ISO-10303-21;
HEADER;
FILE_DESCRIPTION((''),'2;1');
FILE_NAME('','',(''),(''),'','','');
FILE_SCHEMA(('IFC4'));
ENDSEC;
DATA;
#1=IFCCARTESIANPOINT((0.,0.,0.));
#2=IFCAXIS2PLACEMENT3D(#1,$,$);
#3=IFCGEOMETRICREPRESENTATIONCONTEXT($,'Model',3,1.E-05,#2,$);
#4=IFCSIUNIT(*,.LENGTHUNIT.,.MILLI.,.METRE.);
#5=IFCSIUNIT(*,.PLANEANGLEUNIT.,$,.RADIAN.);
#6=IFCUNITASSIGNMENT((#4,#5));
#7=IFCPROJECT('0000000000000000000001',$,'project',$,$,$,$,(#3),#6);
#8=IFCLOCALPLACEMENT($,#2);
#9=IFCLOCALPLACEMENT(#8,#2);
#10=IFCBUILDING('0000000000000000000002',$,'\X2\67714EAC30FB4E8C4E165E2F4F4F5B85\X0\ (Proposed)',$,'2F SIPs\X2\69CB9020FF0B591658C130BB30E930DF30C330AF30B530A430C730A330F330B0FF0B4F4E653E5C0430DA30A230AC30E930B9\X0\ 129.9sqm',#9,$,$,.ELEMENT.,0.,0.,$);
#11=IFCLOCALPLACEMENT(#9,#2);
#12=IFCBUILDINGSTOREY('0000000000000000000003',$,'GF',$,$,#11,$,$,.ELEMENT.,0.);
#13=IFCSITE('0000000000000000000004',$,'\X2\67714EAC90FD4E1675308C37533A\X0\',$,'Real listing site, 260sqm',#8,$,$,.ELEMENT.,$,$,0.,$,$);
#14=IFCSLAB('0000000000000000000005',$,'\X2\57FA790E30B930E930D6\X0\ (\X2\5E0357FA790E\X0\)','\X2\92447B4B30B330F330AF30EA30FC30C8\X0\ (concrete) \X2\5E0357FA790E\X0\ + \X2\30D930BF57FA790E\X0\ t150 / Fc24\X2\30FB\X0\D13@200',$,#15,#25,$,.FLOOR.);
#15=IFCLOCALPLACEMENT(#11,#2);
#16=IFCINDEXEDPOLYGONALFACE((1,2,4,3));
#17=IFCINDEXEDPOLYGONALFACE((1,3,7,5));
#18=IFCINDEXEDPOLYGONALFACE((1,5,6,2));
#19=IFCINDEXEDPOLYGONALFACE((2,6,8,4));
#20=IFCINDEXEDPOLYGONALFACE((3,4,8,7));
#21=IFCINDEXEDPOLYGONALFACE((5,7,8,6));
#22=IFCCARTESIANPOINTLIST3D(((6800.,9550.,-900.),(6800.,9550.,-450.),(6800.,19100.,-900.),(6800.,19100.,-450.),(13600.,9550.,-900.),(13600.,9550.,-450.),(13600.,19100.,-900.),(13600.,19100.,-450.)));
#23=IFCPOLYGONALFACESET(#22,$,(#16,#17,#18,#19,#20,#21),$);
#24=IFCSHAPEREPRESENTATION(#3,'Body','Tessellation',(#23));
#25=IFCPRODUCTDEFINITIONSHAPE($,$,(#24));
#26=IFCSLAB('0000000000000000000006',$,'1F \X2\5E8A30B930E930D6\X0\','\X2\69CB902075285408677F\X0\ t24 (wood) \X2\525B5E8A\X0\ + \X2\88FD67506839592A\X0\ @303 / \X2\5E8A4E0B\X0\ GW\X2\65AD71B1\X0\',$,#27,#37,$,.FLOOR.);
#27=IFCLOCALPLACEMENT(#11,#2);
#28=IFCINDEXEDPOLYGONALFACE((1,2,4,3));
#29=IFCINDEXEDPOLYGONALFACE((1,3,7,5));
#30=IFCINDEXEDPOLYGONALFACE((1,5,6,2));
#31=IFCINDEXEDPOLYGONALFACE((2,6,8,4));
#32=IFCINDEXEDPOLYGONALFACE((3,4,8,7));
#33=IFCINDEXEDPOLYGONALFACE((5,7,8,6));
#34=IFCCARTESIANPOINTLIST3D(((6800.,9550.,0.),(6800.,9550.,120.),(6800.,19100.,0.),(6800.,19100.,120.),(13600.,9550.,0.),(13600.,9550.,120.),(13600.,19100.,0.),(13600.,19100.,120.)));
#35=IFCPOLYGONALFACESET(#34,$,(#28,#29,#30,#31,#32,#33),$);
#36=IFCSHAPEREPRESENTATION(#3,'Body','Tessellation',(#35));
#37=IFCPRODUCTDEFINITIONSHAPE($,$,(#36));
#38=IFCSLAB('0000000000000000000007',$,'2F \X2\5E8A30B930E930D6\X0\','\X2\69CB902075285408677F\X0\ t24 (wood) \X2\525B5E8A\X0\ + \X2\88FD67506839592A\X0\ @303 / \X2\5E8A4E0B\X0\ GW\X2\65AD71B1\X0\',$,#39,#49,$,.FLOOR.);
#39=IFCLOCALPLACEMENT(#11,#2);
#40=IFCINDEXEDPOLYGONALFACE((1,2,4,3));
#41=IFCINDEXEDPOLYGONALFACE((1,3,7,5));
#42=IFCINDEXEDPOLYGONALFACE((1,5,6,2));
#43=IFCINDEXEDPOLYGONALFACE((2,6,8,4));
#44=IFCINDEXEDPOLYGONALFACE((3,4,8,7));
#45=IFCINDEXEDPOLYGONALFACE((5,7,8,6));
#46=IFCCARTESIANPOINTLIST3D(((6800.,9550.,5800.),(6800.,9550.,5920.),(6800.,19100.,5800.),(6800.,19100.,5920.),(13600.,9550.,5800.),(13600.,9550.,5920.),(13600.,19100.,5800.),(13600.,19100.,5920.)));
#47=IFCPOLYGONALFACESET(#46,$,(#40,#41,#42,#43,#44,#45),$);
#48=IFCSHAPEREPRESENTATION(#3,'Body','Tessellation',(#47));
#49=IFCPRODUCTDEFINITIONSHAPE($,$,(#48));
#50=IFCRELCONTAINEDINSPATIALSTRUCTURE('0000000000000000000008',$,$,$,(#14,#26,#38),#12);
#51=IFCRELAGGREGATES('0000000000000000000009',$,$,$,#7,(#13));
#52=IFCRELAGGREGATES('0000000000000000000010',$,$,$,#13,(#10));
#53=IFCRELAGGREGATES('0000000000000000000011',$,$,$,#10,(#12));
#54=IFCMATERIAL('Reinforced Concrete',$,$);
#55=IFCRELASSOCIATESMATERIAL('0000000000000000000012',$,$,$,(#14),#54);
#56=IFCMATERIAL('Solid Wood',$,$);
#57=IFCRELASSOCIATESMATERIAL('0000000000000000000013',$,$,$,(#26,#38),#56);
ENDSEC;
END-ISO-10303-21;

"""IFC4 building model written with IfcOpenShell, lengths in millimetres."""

from ifc_helpers import new_model, si_unit, frame, frame_2d, origin, place, context, project, spatial, rectangle, extrude, material, element, save


model = new_model("IFC4")

# Units and contexts
model_context = context("Model", 3, precision=1e-05, world=origin())
ifc_project = project(units=[si_unit("LENGTHUNIT", "METRE", prefix="MILLI"), si_unit("PLANEANGLEUNIT", "RADIAN")], contexts=[model_context])

# Site, building, storey
site_placement = place(None, origin())
site = spatial("IfcSite", under=ifc_project, at=site_placement, Name="東京都世田谷区", ObjectType="Real listing site, 260sqm", CompositionType="ELEMENT", RefElevation=0.0)
building_placement = place(site_placement, origin())
building = spatial("IfcBuilding", under=site, at=building_placement, Name="東京・二世帯住宅 (Proposed)", ObjectType="2F SIPs構造＋外壁セラミックサイディング＋低放射ペアガラス 129.9sqm", CompositionType="ELEMENT", ElevationOfRefHeight=0.0, ElevationOfTerrain=0.0)
storey_placement = place(building_placement, origin())
storey = spatial("IfcBuildingStorey", under=building, at=storey_placement, Name="GF", CompositionType="ELEMENT", Elevation=0.0)

# Shared definitions
ifc_material_1 = material(Name="Solid Wood")

# Slabs
ifc_material_2 = material(Name="Reinforced Concrete")
slab_1_placement = place(storey_placement, frame((3400.0, 4775.0, -450.0)))
element("IfcSlab", 1, at=slab_1_placement, inside=storey, material=ifc_material_2, Name="基礎スラブ (布基礎)", Description="鉄筋コンクリート (concrete) 布基礎 + ベタ基礎 t150 / Fc24・D13@200", PredefinedType="FLOOR", context=model_context, shape_type="SweptSolid", body=[
    extrude(rectangle(XDim=6800.0, YDim=9550.0, at=frame_2d((3400.0, 4775.0))), frame((3400.0, 4775.0, -450.0)), (0.0, 0.0, 1.0), 450.0),
])
slab_2_placement = place(storey_placement, frame((3400.0, 4775.0, 0.0)))
element("IfcSlab", 2, at=slab_2_placement, inside=storey, material=ifc_material_1, Name="1F 床スラブ", Description="構造用合板 t24 (wood) 剛床 + 製材根太 @303 / 床下 GW断熱", PredefinedType="FLOOR", context=model_context, shape_type="SweptSolid", body=[
    extrude(rectangle(XDim=6800.0, YDim=9550.0, at=frame_2d((3400.0, 4775.0))), frame((3400.0, 4775.0, 0.0)), (0.0, 0.0, 1.0), 120.0),
])
slab_3_placement = place(storey_placement, frame((3400.0, 4775.0, 2900.0)))
element("IfcSlab", 3, at=slab_3_placement, inside=storey, material=ifc_material_1, Name="2F 床スラブ", Description="構造用合板 t24 (wood) 剛床 + 製材根太 @303 / 床下 GW断熱", PredefinedType="FLOOR", context=model_context, shape_type="SweptSolid", body=[
    extrude(rectangle(XDim=6800.0, YDim=9550.0, at=frame_2d((3400.0, 4775.0))), frame((3400.0, 4775.0, 2900.0)), (0.0, 0.0, 1.0), 120.0),
])

save(model, "model.ifc")
